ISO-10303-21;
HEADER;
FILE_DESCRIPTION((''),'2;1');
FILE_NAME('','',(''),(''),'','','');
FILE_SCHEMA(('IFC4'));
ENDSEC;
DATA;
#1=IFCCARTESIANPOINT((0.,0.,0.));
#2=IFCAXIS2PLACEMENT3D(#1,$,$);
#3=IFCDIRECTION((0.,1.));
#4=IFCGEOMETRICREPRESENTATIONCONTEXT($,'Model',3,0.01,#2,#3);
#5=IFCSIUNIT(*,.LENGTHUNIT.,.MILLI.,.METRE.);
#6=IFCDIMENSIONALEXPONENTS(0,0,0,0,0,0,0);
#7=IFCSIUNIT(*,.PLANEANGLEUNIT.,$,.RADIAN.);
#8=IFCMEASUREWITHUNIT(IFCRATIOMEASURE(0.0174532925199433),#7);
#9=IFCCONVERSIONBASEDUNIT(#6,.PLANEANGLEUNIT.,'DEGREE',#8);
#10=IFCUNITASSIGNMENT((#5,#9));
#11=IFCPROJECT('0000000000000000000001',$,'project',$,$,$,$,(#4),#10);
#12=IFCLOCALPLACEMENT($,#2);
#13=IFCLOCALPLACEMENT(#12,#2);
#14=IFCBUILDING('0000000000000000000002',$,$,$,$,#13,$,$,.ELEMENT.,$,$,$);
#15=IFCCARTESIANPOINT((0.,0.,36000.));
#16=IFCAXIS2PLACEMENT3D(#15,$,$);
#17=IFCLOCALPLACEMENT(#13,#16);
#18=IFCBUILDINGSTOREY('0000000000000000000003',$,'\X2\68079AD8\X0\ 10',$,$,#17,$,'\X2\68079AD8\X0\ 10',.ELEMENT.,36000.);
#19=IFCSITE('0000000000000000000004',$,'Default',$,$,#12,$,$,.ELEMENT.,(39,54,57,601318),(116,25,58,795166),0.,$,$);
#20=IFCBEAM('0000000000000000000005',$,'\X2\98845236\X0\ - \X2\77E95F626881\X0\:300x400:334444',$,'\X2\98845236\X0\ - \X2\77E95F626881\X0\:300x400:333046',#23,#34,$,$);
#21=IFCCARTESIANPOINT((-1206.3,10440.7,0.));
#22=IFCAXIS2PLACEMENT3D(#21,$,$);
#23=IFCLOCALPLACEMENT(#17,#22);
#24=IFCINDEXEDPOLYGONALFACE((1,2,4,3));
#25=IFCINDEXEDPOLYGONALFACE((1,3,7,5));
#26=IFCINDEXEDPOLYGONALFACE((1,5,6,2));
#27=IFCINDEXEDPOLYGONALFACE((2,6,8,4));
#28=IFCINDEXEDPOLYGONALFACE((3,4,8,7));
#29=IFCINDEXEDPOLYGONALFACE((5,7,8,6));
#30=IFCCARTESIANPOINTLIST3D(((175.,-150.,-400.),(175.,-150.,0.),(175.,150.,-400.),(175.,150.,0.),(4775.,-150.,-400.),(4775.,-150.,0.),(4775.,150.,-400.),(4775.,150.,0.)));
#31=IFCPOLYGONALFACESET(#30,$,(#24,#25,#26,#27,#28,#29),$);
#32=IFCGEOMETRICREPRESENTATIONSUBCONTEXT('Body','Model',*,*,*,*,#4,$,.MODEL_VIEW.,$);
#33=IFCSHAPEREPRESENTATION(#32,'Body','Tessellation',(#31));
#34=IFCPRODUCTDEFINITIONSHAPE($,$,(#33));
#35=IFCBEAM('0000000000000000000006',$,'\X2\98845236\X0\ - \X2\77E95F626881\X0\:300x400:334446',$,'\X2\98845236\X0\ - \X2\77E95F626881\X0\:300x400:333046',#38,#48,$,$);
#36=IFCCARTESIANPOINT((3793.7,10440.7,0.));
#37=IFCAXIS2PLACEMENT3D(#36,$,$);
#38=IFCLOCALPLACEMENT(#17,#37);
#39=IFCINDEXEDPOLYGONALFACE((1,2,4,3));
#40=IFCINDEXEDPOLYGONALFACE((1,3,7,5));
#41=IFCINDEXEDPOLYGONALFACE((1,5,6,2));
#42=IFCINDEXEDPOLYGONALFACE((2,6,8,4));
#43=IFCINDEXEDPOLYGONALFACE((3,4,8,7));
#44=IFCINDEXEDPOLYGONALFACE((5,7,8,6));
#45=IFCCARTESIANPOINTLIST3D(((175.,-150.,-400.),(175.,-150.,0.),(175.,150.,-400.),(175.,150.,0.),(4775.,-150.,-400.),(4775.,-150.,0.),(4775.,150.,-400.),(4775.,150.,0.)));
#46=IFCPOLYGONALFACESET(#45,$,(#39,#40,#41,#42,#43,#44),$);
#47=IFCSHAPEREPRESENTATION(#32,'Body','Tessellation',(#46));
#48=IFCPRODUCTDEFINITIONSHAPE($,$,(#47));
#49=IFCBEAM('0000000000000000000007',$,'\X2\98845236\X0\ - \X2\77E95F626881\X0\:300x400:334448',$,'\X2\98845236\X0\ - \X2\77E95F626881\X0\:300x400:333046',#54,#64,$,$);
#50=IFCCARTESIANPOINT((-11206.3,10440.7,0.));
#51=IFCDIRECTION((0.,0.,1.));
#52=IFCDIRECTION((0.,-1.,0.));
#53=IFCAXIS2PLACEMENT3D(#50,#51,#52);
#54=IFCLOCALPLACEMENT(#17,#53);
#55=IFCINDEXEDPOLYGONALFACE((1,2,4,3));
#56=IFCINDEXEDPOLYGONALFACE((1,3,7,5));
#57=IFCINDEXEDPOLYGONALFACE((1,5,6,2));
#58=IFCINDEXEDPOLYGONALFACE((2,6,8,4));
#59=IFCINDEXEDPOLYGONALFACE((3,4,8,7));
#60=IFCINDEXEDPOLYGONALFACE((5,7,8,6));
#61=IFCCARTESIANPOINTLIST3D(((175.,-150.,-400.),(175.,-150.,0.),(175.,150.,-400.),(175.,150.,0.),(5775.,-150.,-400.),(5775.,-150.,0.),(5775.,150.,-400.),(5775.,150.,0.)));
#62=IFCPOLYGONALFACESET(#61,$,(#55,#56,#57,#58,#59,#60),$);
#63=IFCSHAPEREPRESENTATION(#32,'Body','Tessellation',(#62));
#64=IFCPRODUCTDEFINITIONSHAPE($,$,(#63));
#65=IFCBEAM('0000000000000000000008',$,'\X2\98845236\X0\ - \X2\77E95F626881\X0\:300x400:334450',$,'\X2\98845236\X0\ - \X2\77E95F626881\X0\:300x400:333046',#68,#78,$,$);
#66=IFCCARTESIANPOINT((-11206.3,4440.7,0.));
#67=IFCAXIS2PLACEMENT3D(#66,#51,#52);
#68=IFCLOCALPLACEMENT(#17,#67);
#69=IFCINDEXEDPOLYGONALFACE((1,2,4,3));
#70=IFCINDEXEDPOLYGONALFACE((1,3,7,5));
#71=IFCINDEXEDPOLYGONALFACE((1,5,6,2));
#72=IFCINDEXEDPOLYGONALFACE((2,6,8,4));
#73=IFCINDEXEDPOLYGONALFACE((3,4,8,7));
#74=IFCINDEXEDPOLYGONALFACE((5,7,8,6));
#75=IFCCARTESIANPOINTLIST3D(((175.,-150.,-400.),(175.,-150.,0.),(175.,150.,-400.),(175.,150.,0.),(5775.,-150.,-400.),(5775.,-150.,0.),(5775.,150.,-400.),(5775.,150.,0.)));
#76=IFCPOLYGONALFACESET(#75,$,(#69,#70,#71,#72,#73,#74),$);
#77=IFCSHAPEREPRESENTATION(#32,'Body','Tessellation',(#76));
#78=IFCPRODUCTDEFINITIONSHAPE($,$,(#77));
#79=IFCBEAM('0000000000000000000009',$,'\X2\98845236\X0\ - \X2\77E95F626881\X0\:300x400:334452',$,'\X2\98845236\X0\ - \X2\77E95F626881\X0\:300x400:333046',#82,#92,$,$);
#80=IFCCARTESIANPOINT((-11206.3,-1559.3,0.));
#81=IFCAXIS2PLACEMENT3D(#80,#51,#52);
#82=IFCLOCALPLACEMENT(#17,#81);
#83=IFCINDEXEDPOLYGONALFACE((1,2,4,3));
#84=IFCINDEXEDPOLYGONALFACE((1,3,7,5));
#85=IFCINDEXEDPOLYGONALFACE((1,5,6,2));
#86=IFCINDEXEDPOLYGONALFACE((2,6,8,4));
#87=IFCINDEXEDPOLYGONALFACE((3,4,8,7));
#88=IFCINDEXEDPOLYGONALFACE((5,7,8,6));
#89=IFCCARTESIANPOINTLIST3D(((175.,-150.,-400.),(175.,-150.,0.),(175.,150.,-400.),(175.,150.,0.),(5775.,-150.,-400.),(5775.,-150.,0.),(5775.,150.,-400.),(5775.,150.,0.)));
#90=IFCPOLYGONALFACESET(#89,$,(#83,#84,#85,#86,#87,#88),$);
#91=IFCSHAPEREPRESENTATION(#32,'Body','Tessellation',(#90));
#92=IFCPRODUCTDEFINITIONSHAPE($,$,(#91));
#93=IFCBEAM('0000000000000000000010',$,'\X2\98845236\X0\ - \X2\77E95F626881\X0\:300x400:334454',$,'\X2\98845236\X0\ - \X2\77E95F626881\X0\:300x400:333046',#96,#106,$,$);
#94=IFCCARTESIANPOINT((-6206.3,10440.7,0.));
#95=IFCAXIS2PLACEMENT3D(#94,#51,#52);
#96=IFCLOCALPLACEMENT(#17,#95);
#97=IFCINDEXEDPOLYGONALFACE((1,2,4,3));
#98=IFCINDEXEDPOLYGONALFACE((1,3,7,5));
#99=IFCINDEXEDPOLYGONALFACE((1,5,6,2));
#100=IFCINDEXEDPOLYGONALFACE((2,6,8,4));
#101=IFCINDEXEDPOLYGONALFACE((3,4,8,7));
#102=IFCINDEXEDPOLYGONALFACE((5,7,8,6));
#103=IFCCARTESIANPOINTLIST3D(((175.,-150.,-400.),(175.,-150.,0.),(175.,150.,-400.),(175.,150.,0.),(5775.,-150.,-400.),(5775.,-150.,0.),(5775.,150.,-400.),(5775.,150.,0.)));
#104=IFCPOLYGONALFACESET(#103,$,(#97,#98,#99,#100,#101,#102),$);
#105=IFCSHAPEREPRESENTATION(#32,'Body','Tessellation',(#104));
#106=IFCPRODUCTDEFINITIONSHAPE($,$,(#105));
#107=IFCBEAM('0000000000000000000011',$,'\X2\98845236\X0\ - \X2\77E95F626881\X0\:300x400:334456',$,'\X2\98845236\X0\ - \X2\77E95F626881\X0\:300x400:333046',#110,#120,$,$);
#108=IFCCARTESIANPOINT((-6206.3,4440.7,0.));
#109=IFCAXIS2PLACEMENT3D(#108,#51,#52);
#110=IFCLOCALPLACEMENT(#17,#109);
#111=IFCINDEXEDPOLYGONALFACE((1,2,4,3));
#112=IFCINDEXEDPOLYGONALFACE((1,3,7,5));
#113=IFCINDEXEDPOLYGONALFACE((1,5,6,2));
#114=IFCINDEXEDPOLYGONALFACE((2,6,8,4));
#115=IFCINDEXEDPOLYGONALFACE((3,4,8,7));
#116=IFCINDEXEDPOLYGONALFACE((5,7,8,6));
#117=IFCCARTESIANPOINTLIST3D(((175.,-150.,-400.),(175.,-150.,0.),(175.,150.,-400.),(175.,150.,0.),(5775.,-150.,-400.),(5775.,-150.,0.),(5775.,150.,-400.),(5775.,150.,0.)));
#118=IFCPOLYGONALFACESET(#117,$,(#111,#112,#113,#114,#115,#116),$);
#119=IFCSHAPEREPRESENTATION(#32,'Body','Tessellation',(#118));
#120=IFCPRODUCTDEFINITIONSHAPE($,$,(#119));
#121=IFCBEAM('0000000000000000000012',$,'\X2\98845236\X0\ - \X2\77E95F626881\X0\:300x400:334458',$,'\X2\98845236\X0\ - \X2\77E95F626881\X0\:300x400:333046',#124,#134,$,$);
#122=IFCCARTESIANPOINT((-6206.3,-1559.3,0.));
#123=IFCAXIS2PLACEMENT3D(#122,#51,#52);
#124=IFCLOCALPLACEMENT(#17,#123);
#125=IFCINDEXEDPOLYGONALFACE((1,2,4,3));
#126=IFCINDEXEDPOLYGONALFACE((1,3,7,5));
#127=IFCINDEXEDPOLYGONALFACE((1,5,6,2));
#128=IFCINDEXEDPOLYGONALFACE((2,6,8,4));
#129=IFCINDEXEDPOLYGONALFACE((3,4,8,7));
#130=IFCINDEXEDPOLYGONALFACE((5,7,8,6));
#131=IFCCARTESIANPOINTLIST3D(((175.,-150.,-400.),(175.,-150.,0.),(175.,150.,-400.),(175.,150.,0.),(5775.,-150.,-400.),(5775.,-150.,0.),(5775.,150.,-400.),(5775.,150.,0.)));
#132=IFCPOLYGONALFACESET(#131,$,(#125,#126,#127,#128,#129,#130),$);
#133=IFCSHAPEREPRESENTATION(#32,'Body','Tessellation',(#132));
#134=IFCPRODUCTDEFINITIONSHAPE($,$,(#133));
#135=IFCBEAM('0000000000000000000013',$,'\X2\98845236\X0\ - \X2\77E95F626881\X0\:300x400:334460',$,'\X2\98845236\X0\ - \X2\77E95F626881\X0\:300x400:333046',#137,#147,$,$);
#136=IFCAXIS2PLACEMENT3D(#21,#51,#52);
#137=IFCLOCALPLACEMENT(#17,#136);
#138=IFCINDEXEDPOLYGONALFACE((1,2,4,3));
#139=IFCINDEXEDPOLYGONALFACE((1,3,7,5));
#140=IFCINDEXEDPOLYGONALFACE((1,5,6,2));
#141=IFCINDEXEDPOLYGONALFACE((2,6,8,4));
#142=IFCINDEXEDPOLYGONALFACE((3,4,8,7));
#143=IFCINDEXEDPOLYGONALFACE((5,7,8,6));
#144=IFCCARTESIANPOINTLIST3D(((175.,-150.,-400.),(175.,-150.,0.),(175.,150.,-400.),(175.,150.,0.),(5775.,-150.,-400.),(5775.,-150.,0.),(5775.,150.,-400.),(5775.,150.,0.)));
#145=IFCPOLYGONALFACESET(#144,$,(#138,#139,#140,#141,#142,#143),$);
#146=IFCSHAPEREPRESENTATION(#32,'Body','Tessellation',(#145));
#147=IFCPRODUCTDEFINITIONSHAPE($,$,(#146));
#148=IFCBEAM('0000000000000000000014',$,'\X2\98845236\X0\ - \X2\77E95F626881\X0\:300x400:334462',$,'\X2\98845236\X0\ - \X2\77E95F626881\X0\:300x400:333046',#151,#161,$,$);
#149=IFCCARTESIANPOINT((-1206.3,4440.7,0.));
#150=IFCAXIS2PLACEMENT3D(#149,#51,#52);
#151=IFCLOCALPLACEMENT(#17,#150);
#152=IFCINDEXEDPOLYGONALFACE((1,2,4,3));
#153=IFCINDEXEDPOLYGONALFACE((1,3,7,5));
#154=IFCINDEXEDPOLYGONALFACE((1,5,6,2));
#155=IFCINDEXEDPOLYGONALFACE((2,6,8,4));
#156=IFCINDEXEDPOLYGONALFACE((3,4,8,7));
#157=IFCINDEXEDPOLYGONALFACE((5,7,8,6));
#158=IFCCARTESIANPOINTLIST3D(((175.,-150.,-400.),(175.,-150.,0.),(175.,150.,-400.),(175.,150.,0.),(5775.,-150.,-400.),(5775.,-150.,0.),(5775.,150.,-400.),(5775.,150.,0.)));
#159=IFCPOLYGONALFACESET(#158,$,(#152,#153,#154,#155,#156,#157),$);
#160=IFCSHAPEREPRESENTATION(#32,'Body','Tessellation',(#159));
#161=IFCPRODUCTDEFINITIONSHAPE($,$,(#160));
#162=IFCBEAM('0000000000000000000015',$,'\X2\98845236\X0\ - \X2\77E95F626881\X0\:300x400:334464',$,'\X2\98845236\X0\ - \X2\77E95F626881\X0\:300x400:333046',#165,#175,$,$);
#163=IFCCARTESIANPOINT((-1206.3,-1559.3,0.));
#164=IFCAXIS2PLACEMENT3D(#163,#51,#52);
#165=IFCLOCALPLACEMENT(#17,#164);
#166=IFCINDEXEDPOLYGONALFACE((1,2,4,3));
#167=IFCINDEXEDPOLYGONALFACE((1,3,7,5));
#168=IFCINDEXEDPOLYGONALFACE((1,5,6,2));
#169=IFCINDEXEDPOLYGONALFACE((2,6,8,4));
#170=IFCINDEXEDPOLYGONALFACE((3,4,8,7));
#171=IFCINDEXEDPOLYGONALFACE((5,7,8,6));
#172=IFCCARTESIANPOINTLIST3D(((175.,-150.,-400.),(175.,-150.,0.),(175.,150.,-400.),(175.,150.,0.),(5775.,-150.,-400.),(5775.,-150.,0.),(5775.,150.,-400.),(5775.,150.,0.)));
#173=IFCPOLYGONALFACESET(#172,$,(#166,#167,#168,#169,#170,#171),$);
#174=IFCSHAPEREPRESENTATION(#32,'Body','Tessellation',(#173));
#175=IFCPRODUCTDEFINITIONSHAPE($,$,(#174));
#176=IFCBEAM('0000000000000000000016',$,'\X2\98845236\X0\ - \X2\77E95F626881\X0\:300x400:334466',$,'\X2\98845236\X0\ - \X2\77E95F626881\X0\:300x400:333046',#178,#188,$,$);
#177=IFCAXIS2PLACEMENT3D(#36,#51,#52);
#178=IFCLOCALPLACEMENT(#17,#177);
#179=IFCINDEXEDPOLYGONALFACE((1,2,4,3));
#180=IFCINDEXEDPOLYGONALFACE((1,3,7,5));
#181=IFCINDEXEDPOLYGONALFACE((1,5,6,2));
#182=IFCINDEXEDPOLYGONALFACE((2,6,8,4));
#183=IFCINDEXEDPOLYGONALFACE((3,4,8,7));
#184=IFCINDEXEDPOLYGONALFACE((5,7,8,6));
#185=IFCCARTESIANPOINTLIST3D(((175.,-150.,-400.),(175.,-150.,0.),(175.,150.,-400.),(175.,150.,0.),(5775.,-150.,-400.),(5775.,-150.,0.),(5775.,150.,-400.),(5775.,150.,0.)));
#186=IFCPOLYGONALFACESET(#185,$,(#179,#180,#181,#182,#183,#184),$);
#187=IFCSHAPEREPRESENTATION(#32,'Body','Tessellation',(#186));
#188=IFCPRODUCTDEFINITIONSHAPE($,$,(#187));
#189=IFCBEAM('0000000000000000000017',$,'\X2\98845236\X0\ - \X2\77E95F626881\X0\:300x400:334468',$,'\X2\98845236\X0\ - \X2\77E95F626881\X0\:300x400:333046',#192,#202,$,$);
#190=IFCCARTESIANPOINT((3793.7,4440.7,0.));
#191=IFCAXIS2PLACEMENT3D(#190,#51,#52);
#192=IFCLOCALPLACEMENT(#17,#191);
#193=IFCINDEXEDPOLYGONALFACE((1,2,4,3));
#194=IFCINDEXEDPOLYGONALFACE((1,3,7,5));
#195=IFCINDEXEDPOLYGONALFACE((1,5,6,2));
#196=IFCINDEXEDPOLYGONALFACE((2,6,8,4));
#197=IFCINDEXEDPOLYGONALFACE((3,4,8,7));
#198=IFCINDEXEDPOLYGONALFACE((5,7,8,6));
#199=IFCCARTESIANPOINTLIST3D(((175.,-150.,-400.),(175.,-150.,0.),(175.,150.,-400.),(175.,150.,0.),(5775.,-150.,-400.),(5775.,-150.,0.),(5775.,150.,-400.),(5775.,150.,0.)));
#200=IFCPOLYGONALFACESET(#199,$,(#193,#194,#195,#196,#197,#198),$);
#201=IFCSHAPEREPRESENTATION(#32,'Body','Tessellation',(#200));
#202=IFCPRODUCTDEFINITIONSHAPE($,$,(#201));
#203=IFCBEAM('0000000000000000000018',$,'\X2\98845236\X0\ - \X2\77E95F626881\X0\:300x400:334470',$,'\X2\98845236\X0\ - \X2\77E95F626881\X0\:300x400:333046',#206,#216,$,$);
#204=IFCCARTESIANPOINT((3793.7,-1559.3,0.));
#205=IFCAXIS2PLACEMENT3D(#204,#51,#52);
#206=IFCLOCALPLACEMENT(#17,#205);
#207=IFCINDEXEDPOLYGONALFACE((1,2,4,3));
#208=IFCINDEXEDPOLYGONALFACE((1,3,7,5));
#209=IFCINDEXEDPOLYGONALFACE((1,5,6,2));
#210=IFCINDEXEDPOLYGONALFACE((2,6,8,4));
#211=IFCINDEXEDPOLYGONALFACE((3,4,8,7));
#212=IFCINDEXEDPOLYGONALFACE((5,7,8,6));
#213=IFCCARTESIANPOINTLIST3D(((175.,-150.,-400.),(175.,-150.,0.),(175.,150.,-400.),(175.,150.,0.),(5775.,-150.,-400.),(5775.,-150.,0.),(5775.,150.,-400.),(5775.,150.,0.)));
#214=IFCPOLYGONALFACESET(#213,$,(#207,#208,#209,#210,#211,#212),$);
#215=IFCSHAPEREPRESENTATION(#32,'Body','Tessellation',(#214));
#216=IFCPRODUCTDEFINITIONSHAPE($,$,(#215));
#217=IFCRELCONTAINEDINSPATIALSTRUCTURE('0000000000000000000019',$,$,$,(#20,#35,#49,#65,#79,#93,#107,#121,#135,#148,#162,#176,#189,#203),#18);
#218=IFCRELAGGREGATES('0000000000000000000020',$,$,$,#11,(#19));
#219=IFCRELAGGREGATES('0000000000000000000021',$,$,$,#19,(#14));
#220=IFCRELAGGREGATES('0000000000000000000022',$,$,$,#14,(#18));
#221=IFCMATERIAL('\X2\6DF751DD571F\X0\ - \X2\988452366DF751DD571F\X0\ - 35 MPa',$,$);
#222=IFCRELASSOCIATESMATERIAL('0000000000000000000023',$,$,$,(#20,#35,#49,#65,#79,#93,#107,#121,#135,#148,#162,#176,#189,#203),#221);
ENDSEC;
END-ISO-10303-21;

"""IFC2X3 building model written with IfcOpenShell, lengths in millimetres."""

from ifc_helpers import new_model, entity, si_unit, converted_unit, direction, frame, frame_2d, origin, origin_2d_with_axis, place, context, subcontext, project, spatial, rectangle, extrude, material, element, save


model = new_model("IFC2X3")

# Units and contexts
model_context = context("Model", 3, precision=0.01, world=origin(), true_north=direction((0.0, 1.0)))
body_context = subcontext(model_context, "Body", "Model", "MODEL_VIEW")
ifc_project = project(units=[si_unit("LENGTHUNIT", "METRE", prefix="MILLI"), converted_unit("PLANEANGLEUNIT", "DEGREE", entity("IfcRatioMeasure", 0.0174532925199433), si_unit("PLANEANGLEUNIT", "RADIAN"), dimensions=[0, 0, 0, 0, 0, 0, 0])], contexts=[model_context])

# Site, building, storey
site_placement = place(None, origin())
site = spatial("IfcSite", under=ifc_project, at=site_placement, Name="Default", CompositionType="ELEMENT", RefLatitude=(39, 54, 57, 601318), RefLongitude=(116, 25, 58, 795166), RefElevation=0.0)
building_placement = place(site_placement, origin())
building = spatial("IfcBuilding", under=site, at=building_placement, CompositionType="ELEMENT")
storey_placement = place(building_placement, frame((0.0, 0.0, 36000.0)))
storey = spatial("IfcBuildingStorey", under=building, at=storey_placement, Name="标高 10", LongName="标高 10", CompositionType="ELEMENT", Elevation=36000.0)

# Beams
ifc_material_1 = material(Name="混凝土 - 预制混凝土 - 35 MPa")
beam_1_placement = place(storey_placement, frame((-1206.3, 10440.7, 0.0)))
element("IfcBeam", 1, at=beam_1_placement, inside=storey, material=ifc_material_1, Name="预制 - 矩形梁:300x400:334444", ObjectType="预制 - 矩形梁:300x400:333046", context=body_context, shape_type="SweptSolid", body=[
    extrude(rectangle(XDim=400.0, YDim=300.0, at=frame_2d((0.0, 0.0), x_axis=(1.0, 0.0))), frame((175.0, 0.0, -200.0), z_axis=(1.0, 0.0, 0.0), x_axis=(0.0, 0.0, -1.0)), (0.0, 0.0, 1.0), 4600.0),
])
beam_2_placement = place(storey_placement, frame((3793.7, 10440.7, 0.0)))
element("IfcBeam", 2, at=beam_2_placement, inside=storey, material=ifc_material_1, Name="预制 - 矩形梁:300x400:334446", ObjectType="预制 - 矩形梁:300x400:333046", context=body_context, shape_type="SweptSolid", body=[
    extrude(rectangle(XDim=400.0, YDim=300.0, at=frame_2d((0.0, 0.0), x_axis=(1.0, 0.0))), frame((175.0, 0.0, -200.0), z_axis=(1.0, 0.0, 0.0), x_axis=(0.0, 0.0, -1.0)), (0.0, 0.0, 1.0), 4600.0),
])
for number, where, z_axis, x_axis, name in (
    (3, (-11206.3, 10440.7, 0.0), (0.0, 0.0, 1.0), (0.0, -1.0, 0.0), "预制 - 矩形梁:300x400:334448"),
    (4, (-11206.3, 4440.7, 0.0), (0.0, 0.0, 1.0), (0.0, -1.0, 0.0), "预制 - 矩形梁:300x400:334450"),
):
    element("IfcBeam", number, at=place(storey_placement, frame(where, z_axis=z_axis, x_axis=x_axis)), inside=storey, material=ifc_material_1, Name=name, ObjectType="预制 - 矩形梁:300x400:333046", context=body_context, shape_type="SweptSolid", body=[
        extrude(rectangle(XDim=400.0, YDim=300.0, at=origin_2d_with_axis()), frame((175.0, 0.0, -200.0), z_axis=(1.0, 0.0, 0.0), x_axis=(0.0, 0.0, -1.0)), (0.0, 0.0, 1.0), 5600.0),
    ])
beam_3_placement = place(storey_placement, frame((-11206.3, -1559.3, 0.0), z_axis=(0.0, 0.0, 1.0), x_axis=(0.0, -1.0, 0.0)))
element("IfcBeam", 5, at=beam_3_placement, inside=storey, material=ifc_material_1, Name="预制 - 矩形梁:300x400:334452", ObjectType="预制 - 矩形梁:300x400:333046", context=body_context, shape_type="SweptSolid", body=[
    extrude(rectangle(XDim=400.0, YDim=300.0, at=frame_2d((0.0, 0.0), x_axis=(1.0, 0.0))), frame((175.0, 0.0, -200.0), z_axis=(1.0, 0.0, 0.0), x_axis=(0.0, 0.0, -1.0)), (0.0, 0.0, 1.0), 5600.0),
])
for number, where, z_axis, x_axis, name in (
    (6, (-6206.3, 10440.7, 0.0), (0.0, 0.0, 1.0), (0.0, -1.0, 0.0), "预制 - 矩形梁:300x400:334454"),
    (7, (-6206.3, 4440.7, 0.0), (0.0, 0.0, 1.0), (0.0, -1.0, 0.0), "预制 - 矩形梁:300x400:334456"),
    (8, (-6206.3, -1559.3, 0.0), (0.0, 0.0, 1.0), (0.0, -1.0, 0.0), "预制 - 矩形梁:300x400:334458"),
):
    element("IfcBeam", number, at=place(storey_placement, frame(where, z_axis=z_axis, x_axis=x_axis)), inside=storey, material=ifc_material_1, Name=name, ObjectType="预制 - 矩形梁:300x400:333046", context=body_context, shape_type="SweptSolid", body=[
        extrude(rectangle(XDim=400.0, YDim=300.0, at=origin_2d_with_axis()), frame((175.0, 0.0, -200.0), z_axis=(1.0, 0.0, 0.0), x_axis=(0.0, 0.0, -1.0)), (0.0, 0.0, 1.0), 5600.0),
    ])
beam_4_placement = place(storey_placement, frame((-1206.3, 10440.7, 0.0), z_axis=(0.0, 0.0, 1.0), x_axis=(0.0, -1.0, 0.0)))
element("IfcBeam", 9, at=beam_4_placement, inside=storey, material=ifc_material_1, Name="预制 - 矩形梁:300x400:334460", ObjectType="预制 - 矩形梁:300x400:333046", context=body_context, shape_type="SweptSolid", body=[
    extrude(rectangle(XDim=400.0, YDim=300.0, at=frame_2d((0.0, 0.0), x_axis=(1.0, 0.0))), frame((175.0, 0.0, -200.0), z_axis=(1.0, 0.0, 0.0), x_axis=(0.0, 0.0, -1.0)), (0.0, 0.0, 1.0), 5600.0),
])
beam_5_placement = place(storey_placement, frame((-1206.3, 4440.7, 0.0), z_axis=(0.0, 0.0, 1.0), x_axis=(0.0, -1.0, 0.0)))
element("IfcBeam", 10, at=beam_5_placement, inside=storey, material=ifc_material_1, Name="预制 - 矩形梁:300x400:334462", ObjectType="预制 - 矩形梁:300x400:333046", context=body_context, shape_type="SweptSolid", body=[
    extrude(rectangle(XDim=400.0, YDim=300.0, at=frame_2d((0.0, 0.0), x_axis=(1.0, 0.0))), frame((175.0, 0.0, -200.0), z_axis=(1.0, 0.0, 0.0), x_axis=(0.0, 0.0, -1.0)), (0.0, 0.0, 1.0), 5600.0),
])
beam_6_placement = place(storey_placement, frame((-1206.3, -1559.3, 0.0), z_axis=(0.0, 0.0, 1.0), x_axis=(0.0, -1.0, 0.0)))
element("IfcBeam", 11, at=beam_6_placement, inside=storey, material=ifc_material_1, Name="预制 - 矩形梁:300x400:334464", ObjectType="预制 - 矩形梁:300x400:333046", context=body_context, shape_type="SweptSolid", body=[
    extrude(rectangle(XDim=400.0, YDim=300.0, at=frame_2d((0.0, 0.0), x_axis=(1.0, 0.0))), frame((175.0, 0.0, -200.0), z_axis=(1.0, 0.0, 0.0), x_axis=(0.0, 0.0, -1.0)), (0.0, 0.0, 1.0), 5600.0),
])
beam_7_placement = place(storey_placement, frame((3793.7, 10440.7, 0.0), z_axis=(0.0, 0.0, 1.0), x_axis=(0.0, -1.0, 0.0)))
element("IfcBeam", 12, at=beam_7_placement, inside=storey, material=ifc_material_1, Name="预制 - 矩形梁:300x400:334466", ObjectType="预制 - 矩形梁:300x400:333046", context=body_context, shape_type="SweptSolid", body=[
    extrude(rectangle(XDim=400.0, YDim=300.0, at=frame_2d((0.0, 0.0), x_axis=(1.0, 0.0))), frame((175.0, 0.0, -200.0), z_axis=(1.0, 0.0, 0.0), x_axis=(0.0, 0.0, -1.0)), (0.0, 0.0, 1.0), 5600.0),
])
beam_8_placement = place(storey_placement, frame((3793.7, 4440.7, 0.0), z_axis=(0.0, 0.0, 1.0), x_axis=(0.0, -1.0, 0.0)))
element("IfcBeam", 13, at=beam_8_placement, inside=storey, material=ifc_material_1, Name="预制 - 矩形梁:300x400:334468", ObjectType="预制 - 矩形梁:300x400:333046", context=body_context, shape_type="SweptSolid", body=[
    extrude(rectangle(XDim=400.0, YDim=300.0, at=origin_2d_with_axis()), frame((175.0, 0.0, -200.0), z_axis=(1.0, 0.0, 0.0), x_axis=(0.0, 0.0, -1.0)), (0.0, 0.0, 1.0), 5600.0),
])
beam_9_placement = place(storey_placement, frame((3793.7, -1559.3, 0.0), z_axis=(0.0, 0.0, 1.0), x_axis=(0.0, -1.0, 0.0)))
element("IfcBeam", 14, at=beam_9_placement, inside=storey, material=ifc_material_1, Name="预制 - 矩形梁:300x400:334470", ObjectType="预制 - 矩形梁:300x400:333046", context=body_context, shape_type="SweptSolid", body=[
    extrude(rectangle(XDim=400.0, YDim=300.0, at=frame_2d((0.0, 0.0), x_axis=(1.0, 0.0))), frame((175.0, 0.0, -200.0), z_axis=(1.0, 0.0, 0.0), x_axis=(0.0, 0.0, -1.0)), (0.0, 0.0, 1.0), 5600.0),
])

save(model, "model.ifc")
